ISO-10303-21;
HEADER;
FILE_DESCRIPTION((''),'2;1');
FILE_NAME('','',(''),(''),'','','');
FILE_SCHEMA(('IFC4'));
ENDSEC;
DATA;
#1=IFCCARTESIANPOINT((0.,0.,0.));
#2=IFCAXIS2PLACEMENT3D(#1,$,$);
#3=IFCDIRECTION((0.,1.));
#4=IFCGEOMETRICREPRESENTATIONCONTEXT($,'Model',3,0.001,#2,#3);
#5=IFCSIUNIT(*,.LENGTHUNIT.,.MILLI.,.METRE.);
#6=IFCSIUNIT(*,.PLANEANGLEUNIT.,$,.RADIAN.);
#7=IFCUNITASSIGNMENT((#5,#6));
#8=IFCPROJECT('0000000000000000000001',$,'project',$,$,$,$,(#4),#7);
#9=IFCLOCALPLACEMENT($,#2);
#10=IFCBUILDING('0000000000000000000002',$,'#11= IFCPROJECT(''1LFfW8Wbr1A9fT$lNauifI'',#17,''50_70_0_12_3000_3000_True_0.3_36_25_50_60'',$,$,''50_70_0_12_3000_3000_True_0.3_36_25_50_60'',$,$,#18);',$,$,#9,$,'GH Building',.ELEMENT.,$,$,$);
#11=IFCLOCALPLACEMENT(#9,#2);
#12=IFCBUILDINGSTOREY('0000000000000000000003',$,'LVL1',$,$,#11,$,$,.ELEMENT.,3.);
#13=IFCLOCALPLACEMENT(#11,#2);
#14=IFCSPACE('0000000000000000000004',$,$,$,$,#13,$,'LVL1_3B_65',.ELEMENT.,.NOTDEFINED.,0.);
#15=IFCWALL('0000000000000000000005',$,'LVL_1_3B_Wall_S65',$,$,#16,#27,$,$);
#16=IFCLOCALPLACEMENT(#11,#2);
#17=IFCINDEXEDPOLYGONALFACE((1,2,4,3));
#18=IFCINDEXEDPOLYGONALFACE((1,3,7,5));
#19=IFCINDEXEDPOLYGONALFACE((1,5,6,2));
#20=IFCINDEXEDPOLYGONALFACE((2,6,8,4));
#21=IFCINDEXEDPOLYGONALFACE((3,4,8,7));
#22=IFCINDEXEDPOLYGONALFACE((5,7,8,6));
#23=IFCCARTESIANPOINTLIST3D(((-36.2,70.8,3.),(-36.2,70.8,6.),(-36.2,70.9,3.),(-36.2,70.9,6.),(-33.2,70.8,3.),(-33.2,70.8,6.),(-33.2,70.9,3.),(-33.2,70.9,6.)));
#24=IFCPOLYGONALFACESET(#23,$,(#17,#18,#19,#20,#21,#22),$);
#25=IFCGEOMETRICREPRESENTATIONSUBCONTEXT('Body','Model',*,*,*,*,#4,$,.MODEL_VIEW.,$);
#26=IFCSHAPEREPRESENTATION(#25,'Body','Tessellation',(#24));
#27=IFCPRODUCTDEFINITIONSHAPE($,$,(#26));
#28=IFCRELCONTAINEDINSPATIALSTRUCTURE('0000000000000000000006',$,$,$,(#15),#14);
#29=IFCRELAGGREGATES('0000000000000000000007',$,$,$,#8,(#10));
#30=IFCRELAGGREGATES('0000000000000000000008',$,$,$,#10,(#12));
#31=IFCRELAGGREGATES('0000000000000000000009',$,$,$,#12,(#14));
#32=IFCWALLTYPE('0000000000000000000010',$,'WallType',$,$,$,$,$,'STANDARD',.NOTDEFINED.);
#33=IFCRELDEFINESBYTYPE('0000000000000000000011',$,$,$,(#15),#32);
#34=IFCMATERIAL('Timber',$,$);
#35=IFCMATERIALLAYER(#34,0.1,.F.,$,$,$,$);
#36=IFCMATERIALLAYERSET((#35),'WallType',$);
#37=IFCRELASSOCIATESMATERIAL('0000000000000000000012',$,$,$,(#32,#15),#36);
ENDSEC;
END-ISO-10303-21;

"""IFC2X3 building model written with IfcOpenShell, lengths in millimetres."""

from ifc_helpers import new_model, si_unit, direction, frame, frame_2d, origin, place, context, subcontext, project, spatial, rectangle, extrude, material, layer, layer_set, layer_usage, type_object, element, save


model = new_model("IFC2X3")

# Units and contexts
model_context = context("Model", 3, precision=0.001, world=origin(), true_north=direction((0.0, 1.0)))
body_context = subcontext(model_context, "Body", "Model", "MODEL_VIEW")
ifc_project = project(units=[si_unit("LENGTHUNIT", "METRE", prefix="MILLI"), si_unit("PLANEANGLEUNIT", "RADIAN")], contexts=[model_context])

# Building, storey
building_placement = place(None, origin())
building = spatial("IfcBuilding", under=ifc_project, at=building_placement, Name="#11= IFCPROJECT('1LFfW8Wbr1A9fT$lNauifI',#17,'50_70_0_12_3000_3000_True_0.3_36_25_50_60',$,$,'50_70_0_12_3000_3000_True_0.3_36_25_50_60',$,$,#18);", LongName="GH Building", CompositionType="ELEMENT")
storey_placement = place(building_placement, origin())
storey = spatial("IfcBuildingStorey", under=building, at=storey_placement, Name="LVL1", CompositionType="ELEMENT", Elevation=3.0)

# Shared definitions
space_1_placement = place(storey_placement, origin())
space_1 = spatial("IfcSpace", under=storey, at=space_1_placement, LongName="LVL1_3B_65", CompositionType="ELEMENT", InteriorOrExteriorSpace="NOTDEFINED", ElevationWithFlooring=0.0)

# Wall
ifc_material_1 = material(Name="Timber")
ifc_layer_1 = layer(ifc_material_1, 0.1, ventilated=False)
ifc_layer_set_1 = layer_set([ifc_layer_1], Name="WallType")
ifc_layer_usage_1 = layer_usage(ifc_layer_set_1, "AXIS2", "NEGATIVE", 0.0)
wall_type_1 = type_object("IfcWallType", Name="WallType", ElementType="STANDARD", PredefinedType="NOTDEFINED", material=ifc_layer_set_1)
wall_1_placement = place(space_1_placement, frame((-33.2, 70.8, 3.0), z_axis=(0.0, 0.0, 1.0), x_axis=(-1.0, 0.0, 0.0)))
element("IfcWall", 1, at=wall_1_placement, inside=space_1, type_object=wall_type_1, material=ifc_layer_usage_1, Name="LVL_1_3B_Wall_S65", context=body_context, shape_type="SweptSolid", body=[
    extrude(rectangle(XDim=3.0, YDim=0.1, at=frame_2d((1.5, -0.1))), origin(), (0.0, 0.0, 1.0), 3.0),
])

save(model, "model.ifc")
